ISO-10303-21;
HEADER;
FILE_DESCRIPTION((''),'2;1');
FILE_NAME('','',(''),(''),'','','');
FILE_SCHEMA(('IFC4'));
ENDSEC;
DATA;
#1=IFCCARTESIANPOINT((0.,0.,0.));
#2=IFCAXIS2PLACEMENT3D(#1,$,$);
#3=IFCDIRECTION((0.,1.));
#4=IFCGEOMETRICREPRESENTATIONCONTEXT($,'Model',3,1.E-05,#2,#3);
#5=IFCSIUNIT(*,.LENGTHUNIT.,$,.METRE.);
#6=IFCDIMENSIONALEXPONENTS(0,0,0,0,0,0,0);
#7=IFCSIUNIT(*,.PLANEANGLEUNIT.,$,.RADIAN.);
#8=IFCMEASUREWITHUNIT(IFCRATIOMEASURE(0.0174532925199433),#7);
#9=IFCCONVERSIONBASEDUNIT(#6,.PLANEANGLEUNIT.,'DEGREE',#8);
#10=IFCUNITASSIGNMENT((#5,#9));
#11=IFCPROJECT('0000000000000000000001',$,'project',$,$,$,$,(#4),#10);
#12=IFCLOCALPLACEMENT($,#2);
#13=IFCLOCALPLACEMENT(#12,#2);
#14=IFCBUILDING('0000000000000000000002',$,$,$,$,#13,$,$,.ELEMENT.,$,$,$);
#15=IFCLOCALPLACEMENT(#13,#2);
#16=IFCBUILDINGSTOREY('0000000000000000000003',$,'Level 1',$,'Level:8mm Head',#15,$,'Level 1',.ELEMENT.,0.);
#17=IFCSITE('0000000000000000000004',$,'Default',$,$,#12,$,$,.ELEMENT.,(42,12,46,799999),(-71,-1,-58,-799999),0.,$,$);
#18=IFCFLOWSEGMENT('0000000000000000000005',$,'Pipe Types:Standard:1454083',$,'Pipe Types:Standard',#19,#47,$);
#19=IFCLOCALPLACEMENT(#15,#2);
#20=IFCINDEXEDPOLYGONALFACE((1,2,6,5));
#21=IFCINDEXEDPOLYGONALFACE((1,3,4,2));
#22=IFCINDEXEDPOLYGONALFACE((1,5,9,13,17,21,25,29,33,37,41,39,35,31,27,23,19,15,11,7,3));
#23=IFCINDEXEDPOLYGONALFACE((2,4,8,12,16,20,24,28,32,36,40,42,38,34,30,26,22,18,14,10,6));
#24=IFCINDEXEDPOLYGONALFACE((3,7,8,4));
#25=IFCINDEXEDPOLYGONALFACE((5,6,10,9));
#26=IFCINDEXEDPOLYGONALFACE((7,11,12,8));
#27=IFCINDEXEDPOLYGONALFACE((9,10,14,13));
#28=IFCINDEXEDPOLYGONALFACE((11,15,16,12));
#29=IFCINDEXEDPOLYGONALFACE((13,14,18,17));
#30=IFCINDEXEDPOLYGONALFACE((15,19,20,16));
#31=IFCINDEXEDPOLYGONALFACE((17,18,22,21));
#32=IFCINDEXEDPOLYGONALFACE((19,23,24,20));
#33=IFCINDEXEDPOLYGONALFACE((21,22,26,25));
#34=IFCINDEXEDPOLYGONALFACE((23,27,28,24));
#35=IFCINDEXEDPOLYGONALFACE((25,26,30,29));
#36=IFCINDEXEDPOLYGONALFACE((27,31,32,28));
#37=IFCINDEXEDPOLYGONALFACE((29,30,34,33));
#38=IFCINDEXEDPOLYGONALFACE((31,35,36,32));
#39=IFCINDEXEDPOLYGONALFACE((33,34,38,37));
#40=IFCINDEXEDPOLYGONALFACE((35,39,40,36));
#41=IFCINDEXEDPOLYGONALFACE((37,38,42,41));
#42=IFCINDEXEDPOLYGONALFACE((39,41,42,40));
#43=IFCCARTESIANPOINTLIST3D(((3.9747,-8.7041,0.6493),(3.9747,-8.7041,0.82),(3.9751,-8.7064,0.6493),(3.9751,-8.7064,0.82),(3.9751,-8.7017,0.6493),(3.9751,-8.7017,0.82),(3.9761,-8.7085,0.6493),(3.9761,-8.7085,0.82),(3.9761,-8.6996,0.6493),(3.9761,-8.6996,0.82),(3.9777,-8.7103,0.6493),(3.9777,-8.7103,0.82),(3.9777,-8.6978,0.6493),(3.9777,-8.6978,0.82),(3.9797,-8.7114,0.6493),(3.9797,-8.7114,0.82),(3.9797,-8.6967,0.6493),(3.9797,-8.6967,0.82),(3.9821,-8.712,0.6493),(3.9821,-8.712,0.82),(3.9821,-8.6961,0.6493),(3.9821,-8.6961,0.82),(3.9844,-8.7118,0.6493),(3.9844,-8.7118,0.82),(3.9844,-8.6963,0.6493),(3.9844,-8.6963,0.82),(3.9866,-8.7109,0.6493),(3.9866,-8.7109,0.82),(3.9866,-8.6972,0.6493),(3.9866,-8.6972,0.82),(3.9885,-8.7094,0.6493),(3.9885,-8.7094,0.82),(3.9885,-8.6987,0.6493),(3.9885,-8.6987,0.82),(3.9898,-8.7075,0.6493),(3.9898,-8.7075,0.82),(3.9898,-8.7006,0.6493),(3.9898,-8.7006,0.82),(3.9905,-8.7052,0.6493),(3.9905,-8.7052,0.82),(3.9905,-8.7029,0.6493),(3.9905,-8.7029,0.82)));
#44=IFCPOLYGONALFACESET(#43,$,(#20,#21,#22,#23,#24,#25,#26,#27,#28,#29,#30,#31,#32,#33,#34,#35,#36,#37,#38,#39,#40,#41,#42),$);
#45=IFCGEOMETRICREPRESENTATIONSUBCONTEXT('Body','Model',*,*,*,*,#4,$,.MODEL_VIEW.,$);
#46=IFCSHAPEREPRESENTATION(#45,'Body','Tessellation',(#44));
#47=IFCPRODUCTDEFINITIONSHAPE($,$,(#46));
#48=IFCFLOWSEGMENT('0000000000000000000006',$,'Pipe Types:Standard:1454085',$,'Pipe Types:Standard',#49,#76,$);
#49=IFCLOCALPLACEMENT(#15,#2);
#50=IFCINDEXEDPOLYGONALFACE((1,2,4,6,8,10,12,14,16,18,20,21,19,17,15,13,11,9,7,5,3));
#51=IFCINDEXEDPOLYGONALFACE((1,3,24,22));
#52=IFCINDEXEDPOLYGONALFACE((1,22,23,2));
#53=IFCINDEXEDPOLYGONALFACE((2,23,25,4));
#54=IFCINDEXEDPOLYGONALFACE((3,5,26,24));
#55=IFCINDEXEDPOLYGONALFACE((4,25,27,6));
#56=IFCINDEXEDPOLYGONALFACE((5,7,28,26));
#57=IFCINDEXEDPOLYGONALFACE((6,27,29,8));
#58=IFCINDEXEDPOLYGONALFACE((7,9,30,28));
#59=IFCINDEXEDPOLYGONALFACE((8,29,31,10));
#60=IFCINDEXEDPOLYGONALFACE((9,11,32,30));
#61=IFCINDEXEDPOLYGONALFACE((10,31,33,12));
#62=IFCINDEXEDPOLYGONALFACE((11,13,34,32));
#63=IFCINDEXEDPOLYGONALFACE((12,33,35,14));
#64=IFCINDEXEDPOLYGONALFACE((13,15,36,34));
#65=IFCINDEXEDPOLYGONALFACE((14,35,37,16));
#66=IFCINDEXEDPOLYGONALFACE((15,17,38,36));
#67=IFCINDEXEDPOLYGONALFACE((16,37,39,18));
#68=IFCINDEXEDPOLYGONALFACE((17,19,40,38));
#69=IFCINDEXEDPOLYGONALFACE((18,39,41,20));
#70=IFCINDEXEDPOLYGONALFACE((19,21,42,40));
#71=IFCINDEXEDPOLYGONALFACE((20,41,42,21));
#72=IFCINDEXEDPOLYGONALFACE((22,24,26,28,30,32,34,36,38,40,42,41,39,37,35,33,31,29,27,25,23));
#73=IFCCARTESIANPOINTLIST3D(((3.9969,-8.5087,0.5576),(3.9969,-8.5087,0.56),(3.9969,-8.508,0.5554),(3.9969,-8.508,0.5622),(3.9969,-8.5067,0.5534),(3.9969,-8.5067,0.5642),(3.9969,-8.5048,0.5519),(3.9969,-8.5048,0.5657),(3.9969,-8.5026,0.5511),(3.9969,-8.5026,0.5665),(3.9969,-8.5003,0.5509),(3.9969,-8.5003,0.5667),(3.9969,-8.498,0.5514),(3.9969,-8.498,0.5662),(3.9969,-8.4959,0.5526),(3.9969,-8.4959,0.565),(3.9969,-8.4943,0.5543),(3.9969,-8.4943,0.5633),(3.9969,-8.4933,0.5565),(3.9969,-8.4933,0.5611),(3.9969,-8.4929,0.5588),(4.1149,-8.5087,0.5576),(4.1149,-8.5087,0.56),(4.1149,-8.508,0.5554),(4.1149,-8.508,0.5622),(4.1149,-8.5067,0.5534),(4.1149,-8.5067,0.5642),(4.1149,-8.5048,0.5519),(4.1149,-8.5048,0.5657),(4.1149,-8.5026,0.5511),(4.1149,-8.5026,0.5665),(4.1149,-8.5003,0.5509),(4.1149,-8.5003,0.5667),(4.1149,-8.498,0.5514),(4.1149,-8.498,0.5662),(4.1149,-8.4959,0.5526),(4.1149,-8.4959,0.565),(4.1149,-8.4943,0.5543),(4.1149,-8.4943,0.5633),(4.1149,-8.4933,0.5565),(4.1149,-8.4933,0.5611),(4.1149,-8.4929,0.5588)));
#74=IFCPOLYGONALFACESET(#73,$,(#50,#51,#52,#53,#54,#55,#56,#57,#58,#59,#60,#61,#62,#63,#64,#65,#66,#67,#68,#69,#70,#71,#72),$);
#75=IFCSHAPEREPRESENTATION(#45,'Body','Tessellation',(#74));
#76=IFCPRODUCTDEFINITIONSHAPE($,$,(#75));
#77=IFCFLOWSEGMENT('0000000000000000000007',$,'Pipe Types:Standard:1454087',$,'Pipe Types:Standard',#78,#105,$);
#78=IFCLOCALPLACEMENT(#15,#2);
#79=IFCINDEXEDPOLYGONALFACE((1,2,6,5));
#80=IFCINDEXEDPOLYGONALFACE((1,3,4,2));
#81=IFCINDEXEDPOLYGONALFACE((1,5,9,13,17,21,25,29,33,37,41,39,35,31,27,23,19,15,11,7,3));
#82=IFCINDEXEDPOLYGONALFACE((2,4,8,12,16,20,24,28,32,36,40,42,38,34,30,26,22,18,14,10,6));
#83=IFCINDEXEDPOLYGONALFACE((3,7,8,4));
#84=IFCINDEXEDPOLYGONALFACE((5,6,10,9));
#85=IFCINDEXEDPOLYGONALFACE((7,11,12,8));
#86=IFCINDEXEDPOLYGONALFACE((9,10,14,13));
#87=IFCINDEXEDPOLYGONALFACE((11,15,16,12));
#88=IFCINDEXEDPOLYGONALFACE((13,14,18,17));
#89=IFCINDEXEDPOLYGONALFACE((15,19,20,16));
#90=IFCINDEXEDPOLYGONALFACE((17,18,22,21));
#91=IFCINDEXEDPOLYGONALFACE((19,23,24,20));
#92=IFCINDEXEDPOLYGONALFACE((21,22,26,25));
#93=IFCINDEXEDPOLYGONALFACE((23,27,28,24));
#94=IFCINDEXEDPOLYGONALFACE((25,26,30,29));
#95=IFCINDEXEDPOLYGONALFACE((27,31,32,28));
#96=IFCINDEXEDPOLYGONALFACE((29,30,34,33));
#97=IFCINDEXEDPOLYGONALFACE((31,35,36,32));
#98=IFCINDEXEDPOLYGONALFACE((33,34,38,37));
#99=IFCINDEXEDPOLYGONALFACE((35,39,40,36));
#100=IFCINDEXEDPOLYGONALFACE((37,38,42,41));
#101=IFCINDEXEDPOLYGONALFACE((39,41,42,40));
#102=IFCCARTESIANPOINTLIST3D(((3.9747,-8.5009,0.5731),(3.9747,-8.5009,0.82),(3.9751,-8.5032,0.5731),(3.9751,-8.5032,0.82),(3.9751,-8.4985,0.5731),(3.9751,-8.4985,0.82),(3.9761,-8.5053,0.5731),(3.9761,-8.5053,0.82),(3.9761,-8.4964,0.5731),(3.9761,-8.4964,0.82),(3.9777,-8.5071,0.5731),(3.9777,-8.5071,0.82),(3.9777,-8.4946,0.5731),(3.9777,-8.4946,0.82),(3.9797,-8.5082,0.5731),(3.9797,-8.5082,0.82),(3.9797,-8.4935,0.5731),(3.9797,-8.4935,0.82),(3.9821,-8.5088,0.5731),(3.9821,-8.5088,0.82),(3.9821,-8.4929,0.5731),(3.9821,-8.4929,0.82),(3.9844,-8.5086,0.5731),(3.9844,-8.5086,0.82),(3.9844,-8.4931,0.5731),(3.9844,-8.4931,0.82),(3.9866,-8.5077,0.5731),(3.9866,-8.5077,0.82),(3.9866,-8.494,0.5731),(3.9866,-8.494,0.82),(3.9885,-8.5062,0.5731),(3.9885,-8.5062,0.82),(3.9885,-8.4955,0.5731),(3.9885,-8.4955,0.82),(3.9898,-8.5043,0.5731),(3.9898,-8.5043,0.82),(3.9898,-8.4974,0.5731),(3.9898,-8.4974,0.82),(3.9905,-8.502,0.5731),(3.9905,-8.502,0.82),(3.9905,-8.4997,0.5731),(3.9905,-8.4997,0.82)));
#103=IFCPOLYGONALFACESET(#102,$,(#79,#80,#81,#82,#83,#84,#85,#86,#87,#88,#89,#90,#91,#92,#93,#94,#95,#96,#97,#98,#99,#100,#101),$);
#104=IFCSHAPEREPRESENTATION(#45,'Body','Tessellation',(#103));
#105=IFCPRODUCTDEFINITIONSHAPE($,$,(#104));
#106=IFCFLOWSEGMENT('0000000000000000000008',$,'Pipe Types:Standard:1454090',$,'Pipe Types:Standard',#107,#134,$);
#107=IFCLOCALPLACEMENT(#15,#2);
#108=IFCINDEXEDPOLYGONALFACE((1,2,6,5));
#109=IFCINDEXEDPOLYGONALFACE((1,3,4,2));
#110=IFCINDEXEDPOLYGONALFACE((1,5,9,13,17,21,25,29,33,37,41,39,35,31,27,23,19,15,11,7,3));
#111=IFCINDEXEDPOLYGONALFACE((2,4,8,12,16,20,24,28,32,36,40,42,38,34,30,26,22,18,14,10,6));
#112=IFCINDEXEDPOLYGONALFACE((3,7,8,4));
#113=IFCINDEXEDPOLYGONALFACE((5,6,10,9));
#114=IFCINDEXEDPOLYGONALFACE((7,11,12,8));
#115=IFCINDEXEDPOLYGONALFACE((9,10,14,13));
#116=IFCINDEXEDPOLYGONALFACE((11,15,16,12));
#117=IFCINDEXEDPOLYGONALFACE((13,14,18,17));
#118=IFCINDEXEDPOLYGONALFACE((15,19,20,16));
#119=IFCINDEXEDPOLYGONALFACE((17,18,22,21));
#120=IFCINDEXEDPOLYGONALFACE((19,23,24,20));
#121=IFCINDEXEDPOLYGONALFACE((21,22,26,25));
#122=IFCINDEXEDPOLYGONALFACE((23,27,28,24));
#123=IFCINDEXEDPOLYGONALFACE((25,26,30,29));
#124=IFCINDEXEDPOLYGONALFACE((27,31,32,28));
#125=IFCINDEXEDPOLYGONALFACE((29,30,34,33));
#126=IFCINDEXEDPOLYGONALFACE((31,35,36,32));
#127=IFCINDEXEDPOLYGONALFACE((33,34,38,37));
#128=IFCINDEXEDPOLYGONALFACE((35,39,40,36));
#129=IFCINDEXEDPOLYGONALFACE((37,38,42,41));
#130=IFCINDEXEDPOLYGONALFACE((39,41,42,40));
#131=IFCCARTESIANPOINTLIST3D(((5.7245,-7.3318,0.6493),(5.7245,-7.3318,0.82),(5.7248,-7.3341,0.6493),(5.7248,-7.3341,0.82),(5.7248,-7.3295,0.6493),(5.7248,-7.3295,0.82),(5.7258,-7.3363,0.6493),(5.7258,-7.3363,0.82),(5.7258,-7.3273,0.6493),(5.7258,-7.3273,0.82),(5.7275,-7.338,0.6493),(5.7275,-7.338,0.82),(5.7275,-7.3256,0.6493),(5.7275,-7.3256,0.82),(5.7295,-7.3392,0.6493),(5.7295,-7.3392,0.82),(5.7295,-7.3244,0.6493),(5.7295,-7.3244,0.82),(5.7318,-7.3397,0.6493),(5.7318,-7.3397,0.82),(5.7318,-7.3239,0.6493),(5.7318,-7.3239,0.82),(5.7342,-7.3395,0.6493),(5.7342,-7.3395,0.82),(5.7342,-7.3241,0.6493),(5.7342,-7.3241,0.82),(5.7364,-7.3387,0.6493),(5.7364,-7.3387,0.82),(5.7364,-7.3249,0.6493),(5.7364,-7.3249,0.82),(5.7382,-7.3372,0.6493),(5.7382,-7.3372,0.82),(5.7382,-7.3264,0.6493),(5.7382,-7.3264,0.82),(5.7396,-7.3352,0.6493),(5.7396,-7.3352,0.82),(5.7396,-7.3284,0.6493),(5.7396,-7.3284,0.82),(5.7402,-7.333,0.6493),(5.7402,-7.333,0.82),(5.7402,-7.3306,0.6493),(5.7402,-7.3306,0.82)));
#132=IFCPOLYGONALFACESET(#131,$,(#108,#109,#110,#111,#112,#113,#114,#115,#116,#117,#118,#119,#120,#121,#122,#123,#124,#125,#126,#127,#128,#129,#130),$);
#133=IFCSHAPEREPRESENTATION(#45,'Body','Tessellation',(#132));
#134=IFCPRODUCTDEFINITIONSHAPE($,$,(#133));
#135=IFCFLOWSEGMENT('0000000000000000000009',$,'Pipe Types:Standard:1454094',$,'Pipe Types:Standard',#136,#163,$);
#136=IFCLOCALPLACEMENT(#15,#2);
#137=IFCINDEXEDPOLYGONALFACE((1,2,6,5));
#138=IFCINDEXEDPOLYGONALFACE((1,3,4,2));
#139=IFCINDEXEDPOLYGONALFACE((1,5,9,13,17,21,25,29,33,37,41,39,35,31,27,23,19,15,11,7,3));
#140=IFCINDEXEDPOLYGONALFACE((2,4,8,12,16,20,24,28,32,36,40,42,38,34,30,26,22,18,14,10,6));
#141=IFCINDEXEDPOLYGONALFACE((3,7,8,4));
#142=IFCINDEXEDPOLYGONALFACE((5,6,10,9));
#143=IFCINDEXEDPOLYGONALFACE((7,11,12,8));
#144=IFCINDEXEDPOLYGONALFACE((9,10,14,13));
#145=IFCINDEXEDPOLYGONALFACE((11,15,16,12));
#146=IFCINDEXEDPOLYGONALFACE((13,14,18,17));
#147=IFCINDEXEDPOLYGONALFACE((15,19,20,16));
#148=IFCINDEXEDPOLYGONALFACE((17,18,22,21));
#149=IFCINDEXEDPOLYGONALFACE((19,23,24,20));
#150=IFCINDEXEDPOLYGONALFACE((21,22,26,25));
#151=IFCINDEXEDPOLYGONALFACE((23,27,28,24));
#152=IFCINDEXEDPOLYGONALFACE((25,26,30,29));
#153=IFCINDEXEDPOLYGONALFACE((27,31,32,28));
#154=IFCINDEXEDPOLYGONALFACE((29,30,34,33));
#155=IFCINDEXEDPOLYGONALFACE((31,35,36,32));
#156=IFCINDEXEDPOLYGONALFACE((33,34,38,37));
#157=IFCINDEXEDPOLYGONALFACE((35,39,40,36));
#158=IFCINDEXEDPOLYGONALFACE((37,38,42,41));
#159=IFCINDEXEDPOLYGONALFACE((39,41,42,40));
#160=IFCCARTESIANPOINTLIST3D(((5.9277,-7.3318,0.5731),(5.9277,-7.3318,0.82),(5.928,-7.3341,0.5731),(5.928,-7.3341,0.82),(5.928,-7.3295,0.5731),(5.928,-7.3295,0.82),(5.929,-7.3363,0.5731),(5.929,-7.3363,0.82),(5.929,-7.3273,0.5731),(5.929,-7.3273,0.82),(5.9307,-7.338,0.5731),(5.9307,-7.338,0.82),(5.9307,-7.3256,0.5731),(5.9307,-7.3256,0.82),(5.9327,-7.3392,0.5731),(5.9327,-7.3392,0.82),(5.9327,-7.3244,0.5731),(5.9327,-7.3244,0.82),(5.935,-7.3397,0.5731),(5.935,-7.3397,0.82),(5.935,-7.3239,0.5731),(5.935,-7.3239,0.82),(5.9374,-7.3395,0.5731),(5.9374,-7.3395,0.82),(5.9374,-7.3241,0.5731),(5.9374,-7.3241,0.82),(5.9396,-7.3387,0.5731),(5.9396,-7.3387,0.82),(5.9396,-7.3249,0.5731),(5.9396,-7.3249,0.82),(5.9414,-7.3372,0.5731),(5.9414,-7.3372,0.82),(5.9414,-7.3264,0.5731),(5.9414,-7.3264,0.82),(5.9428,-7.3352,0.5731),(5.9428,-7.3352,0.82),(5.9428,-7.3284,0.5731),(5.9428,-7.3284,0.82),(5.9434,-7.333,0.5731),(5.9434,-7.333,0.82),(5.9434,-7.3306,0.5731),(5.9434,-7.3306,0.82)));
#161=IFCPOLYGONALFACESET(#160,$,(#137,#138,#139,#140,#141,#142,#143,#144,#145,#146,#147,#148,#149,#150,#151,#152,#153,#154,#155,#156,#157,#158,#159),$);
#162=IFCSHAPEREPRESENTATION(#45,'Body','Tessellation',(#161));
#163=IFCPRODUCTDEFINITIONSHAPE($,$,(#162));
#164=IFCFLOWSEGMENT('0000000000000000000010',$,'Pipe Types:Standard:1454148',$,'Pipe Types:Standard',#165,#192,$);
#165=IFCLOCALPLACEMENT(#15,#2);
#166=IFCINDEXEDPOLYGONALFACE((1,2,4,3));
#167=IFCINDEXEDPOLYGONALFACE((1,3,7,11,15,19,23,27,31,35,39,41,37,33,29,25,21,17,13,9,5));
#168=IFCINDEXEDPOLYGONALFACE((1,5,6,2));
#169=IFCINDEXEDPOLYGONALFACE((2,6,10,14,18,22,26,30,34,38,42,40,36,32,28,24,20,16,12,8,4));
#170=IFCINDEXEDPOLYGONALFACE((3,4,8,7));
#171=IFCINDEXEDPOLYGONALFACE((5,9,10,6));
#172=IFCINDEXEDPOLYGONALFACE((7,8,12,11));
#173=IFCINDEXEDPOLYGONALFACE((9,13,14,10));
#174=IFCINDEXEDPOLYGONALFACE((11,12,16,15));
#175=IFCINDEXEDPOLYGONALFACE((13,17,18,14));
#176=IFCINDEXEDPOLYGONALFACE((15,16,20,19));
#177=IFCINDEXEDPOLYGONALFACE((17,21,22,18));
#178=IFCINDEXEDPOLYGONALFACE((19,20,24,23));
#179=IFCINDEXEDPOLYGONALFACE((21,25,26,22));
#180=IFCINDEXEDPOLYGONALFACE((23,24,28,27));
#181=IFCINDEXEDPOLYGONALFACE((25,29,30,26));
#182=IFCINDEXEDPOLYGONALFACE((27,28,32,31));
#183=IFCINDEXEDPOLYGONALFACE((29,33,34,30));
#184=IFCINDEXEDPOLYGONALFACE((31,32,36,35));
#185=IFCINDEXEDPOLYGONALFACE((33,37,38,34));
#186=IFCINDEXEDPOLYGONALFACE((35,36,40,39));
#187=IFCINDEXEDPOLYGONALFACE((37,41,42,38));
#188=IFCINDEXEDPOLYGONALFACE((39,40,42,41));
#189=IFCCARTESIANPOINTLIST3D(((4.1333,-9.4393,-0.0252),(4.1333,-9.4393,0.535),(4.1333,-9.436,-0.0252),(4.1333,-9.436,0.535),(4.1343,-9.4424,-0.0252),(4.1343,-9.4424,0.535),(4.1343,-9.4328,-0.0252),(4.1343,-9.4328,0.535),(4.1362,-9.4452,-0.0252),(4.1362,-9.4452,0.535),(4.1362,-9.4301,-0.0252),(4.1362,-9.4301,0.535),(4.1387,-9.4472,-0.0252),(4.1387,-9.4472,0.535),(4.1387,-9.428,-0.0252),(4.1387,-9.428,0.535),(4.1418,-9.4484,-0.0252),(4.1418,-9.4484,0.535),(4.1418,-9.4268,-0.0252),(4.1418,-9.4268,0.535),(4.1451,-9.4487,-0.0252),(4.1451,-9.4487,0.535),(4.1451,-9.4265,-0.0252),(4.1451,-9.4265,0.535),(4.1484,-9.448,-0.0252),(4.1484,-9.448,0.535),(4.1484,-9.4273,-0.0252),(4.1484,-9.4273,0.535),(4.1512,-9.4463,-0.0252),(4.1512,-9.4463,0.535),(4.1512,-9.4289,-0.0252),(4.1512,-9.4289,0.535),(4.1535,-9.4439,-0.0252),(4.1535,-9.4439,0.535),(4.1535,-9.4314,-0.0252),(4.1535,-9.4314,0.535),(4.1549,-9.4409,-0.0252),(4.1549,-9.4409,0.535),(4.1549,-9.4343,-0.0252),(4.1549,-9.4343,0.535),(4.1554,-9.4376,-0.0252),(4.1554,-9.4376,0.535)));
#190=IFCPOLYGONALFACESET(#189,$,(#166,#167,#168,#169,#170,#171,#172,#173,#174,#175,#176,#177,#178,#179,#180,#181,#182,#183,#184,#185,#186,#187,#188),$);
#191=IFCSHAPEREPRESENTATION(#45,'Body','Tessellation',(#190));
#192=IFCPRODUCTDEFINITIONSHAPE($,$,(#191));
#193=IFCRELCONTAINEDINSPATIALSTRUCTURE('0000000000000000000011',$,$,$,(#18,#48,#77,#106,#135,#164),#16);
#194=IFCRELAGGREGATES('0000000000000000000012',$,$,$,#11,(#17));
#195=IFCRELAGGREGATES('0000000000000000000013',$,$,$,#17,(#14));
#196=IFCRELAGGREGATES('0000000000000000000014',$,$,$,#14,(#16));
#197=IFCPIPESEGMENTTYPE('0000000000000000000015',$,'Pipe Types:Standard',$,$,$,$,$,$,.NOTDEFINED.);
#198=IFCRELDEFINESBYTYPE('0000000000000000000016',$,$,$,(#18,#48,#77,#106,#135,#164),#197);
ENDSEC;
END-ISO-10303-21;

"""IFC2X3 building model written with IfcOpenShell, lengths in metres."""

from ifc_helpers import new_model, entity, si_unit, converted_unit, direction, frame, frame_2d, origin, origin_2d_with_axis, place, context, subcontext, project, spatial, circle, extrude, type_object, element, save


model = new_model("IFC2X3")

# Units and contexts
model_context = context("Model", 3, precision=1e-05, world=origin(), true_north=direction((0.0, 1.0)))
body_context = subcontext(model_context, "Body", "Model", "MODEL_VIEW")
ifc_project = project(units=[si_unit("LENGTHUNIT", "METRE"), converted_unit("PLANEANGLEUNIT", "DEGREE", entity("IfcRatioMeasure", 0.0174532925199433), si_unit("PLANEANGLEUNIT", "RADIAN"), dimensions=[0, 0, 0, 0, 0, 0, 0])], contexts=[model_context])

# Site, building, storey
site_placement = place(None, origin())
site = spatial("IfcSite", under=ifc_project, at=site_placement, Name="Default", CompositionType="ELEMENT", RefLatitude=(42, 12, 46, 799999), RefLongitude=(-71, -1, -58, -799999), RefElevation=0.0)
building_placement = place(site_placement, origin())
building = spatial("IfcBuilding", under=site, at=building_placement, CompositionType="ELEMENT")
storey_placement = place(building_placement, origin())
storey = spatial("IfcBuildingStorey", under=building, at=storey_placement, Name="Level 1", ObjectType="Level:8mm Head", LongName="Level 1", CompositionType="ELEMENT", Elevation=0.0)

# Flow segments
pipe_segment_type = type_object("IfcPipeSegmentType", Name="Pipe Types:Standard", PredefinedType="NOTDEFINED")
flow_segment_1_placement = place(storey_placement, origin())
element("IfcFlowSegment", 1, at=flow_segment_1_placement, inside=storey, type_object=pipe_segment_type, Name="Pipe Types:Standard:1454083", ObjectType="Pipe Types:Standard", context=body_context, shape_type="SweptSolid", body=[
    extrude(circle(Radius=0.0079, at=origin_2d_with_axis()), frame((3.9826, -8.7041, 0.6493), z_axis=(0.0, 0.0, 1.0), x_axis=(-1.0, 0.0, 0.0)), (0.0, 0.0, 1.0), 0.1707),
])
flow_segment_2_placement = place(storey_placement, origin())
element("IfcFlowSegment", 2, at=flow_segment_2_placement, inside=storey, type_object=pipe_segment_type, Name="Pipe Types:Standard:1454085", ObjectType="Pipe Types:Standard", context=body_context, shape_type="SweptSolid", body=[
    extrude(circle(Radius=0.0079, at=frame_2d((0.0, 0.0), x_axis=(1.0, 0.0))), frame((3.9969, -8.5009, 0.5588), z_axis=(1.0, 0.0, 0.0), x_axis=(0.0, 1.0, 0.0)), (0.0, 0.0, 1.0), 0.118),
])
flow_segment_3_placement = place(storey_placement, origin())
element("IfcFlowSegment", 3, at=flow_segment_3_placement, inside=storey, type_object=pipe_segment_type, Name="Pipe Types:Standard:1454087", ObjectType="Pipe Types:Standard", context=body_context, shape_type="SweptSolid", body=[
    extrude(circle(Radius=0.0079, at=frame_2d((0.0, 0.0), x_axis=(1.0, 0.0))), frame((3.9826, -8.5009, 0.5731), z_axis=(0.0, 0.0, 1.0), x_axis=(-1.0, 0.0, 0.0)), (0.0, 0.0, 1.0), 0.2469),
])
flow_segment_4_placement = place(storey_placement, origin())
element("IfcFlowSegment", 4, at=flow_segment_4_placement, inside=storey, type_object=pipe_segment_type, Name="Pipe Types:Standard:1454090", ObjectType="Pipe Types:Standard", context=body_context, shape_type="SweptSolid", body=[
    extrude(circle(Radius=0.0079, at=frame_2d((0.0, 0.0), x_axis=(1.0, 0.0))), frame((5.7324, -7.3318, 0.6493), z_axis=(0.0, 0.0, 1.0), x_axis=(-1.0, 0.0, 0.0)), (0.0, 0.0, 1.0), 0.1707),
])
flow_segment_5_placement = place(storey_placement, origin())
element("IfcFlowSegment", 5, at=flow_segment_5_placement, inside=storey, type_object=pipe_segment_type, Name="Pipe Types:Standard:1454094", ObjectType="Pipe Types:Standard", context=body_context, shape_type="SweptSolid", body=[
    extrude(circle(Radius=0.0079, at=origin_2d_with_axis()), frame((5.9356, -7.3318, 0.5731), z_axis=(0.0, 0.0, 1.0), x_axis=(-1.0, 0.0, 0.0)), (0.0, 0.0, 1.0), 0.2469),
])
flow_segment_6_placement = place(storey_placement, origin())
element("IfcFlowSegment", 6, at=flow_segment_6_placement, inside=storey, type_object=pipe_segment_type, Name="Pipe Types:Standard:1454148", ObjectType="Pipe Types:Standard", context=body_context, shape_type="SweptSolid", body=[
    extrude(circle(Radius=0.0111, at=origin_2d_with_axis()), frame((4.1443, -9.4376, -0.0252)), (0.0, 0.0, 1.0), 0.5602),
])

save(model, "model.ifc")
